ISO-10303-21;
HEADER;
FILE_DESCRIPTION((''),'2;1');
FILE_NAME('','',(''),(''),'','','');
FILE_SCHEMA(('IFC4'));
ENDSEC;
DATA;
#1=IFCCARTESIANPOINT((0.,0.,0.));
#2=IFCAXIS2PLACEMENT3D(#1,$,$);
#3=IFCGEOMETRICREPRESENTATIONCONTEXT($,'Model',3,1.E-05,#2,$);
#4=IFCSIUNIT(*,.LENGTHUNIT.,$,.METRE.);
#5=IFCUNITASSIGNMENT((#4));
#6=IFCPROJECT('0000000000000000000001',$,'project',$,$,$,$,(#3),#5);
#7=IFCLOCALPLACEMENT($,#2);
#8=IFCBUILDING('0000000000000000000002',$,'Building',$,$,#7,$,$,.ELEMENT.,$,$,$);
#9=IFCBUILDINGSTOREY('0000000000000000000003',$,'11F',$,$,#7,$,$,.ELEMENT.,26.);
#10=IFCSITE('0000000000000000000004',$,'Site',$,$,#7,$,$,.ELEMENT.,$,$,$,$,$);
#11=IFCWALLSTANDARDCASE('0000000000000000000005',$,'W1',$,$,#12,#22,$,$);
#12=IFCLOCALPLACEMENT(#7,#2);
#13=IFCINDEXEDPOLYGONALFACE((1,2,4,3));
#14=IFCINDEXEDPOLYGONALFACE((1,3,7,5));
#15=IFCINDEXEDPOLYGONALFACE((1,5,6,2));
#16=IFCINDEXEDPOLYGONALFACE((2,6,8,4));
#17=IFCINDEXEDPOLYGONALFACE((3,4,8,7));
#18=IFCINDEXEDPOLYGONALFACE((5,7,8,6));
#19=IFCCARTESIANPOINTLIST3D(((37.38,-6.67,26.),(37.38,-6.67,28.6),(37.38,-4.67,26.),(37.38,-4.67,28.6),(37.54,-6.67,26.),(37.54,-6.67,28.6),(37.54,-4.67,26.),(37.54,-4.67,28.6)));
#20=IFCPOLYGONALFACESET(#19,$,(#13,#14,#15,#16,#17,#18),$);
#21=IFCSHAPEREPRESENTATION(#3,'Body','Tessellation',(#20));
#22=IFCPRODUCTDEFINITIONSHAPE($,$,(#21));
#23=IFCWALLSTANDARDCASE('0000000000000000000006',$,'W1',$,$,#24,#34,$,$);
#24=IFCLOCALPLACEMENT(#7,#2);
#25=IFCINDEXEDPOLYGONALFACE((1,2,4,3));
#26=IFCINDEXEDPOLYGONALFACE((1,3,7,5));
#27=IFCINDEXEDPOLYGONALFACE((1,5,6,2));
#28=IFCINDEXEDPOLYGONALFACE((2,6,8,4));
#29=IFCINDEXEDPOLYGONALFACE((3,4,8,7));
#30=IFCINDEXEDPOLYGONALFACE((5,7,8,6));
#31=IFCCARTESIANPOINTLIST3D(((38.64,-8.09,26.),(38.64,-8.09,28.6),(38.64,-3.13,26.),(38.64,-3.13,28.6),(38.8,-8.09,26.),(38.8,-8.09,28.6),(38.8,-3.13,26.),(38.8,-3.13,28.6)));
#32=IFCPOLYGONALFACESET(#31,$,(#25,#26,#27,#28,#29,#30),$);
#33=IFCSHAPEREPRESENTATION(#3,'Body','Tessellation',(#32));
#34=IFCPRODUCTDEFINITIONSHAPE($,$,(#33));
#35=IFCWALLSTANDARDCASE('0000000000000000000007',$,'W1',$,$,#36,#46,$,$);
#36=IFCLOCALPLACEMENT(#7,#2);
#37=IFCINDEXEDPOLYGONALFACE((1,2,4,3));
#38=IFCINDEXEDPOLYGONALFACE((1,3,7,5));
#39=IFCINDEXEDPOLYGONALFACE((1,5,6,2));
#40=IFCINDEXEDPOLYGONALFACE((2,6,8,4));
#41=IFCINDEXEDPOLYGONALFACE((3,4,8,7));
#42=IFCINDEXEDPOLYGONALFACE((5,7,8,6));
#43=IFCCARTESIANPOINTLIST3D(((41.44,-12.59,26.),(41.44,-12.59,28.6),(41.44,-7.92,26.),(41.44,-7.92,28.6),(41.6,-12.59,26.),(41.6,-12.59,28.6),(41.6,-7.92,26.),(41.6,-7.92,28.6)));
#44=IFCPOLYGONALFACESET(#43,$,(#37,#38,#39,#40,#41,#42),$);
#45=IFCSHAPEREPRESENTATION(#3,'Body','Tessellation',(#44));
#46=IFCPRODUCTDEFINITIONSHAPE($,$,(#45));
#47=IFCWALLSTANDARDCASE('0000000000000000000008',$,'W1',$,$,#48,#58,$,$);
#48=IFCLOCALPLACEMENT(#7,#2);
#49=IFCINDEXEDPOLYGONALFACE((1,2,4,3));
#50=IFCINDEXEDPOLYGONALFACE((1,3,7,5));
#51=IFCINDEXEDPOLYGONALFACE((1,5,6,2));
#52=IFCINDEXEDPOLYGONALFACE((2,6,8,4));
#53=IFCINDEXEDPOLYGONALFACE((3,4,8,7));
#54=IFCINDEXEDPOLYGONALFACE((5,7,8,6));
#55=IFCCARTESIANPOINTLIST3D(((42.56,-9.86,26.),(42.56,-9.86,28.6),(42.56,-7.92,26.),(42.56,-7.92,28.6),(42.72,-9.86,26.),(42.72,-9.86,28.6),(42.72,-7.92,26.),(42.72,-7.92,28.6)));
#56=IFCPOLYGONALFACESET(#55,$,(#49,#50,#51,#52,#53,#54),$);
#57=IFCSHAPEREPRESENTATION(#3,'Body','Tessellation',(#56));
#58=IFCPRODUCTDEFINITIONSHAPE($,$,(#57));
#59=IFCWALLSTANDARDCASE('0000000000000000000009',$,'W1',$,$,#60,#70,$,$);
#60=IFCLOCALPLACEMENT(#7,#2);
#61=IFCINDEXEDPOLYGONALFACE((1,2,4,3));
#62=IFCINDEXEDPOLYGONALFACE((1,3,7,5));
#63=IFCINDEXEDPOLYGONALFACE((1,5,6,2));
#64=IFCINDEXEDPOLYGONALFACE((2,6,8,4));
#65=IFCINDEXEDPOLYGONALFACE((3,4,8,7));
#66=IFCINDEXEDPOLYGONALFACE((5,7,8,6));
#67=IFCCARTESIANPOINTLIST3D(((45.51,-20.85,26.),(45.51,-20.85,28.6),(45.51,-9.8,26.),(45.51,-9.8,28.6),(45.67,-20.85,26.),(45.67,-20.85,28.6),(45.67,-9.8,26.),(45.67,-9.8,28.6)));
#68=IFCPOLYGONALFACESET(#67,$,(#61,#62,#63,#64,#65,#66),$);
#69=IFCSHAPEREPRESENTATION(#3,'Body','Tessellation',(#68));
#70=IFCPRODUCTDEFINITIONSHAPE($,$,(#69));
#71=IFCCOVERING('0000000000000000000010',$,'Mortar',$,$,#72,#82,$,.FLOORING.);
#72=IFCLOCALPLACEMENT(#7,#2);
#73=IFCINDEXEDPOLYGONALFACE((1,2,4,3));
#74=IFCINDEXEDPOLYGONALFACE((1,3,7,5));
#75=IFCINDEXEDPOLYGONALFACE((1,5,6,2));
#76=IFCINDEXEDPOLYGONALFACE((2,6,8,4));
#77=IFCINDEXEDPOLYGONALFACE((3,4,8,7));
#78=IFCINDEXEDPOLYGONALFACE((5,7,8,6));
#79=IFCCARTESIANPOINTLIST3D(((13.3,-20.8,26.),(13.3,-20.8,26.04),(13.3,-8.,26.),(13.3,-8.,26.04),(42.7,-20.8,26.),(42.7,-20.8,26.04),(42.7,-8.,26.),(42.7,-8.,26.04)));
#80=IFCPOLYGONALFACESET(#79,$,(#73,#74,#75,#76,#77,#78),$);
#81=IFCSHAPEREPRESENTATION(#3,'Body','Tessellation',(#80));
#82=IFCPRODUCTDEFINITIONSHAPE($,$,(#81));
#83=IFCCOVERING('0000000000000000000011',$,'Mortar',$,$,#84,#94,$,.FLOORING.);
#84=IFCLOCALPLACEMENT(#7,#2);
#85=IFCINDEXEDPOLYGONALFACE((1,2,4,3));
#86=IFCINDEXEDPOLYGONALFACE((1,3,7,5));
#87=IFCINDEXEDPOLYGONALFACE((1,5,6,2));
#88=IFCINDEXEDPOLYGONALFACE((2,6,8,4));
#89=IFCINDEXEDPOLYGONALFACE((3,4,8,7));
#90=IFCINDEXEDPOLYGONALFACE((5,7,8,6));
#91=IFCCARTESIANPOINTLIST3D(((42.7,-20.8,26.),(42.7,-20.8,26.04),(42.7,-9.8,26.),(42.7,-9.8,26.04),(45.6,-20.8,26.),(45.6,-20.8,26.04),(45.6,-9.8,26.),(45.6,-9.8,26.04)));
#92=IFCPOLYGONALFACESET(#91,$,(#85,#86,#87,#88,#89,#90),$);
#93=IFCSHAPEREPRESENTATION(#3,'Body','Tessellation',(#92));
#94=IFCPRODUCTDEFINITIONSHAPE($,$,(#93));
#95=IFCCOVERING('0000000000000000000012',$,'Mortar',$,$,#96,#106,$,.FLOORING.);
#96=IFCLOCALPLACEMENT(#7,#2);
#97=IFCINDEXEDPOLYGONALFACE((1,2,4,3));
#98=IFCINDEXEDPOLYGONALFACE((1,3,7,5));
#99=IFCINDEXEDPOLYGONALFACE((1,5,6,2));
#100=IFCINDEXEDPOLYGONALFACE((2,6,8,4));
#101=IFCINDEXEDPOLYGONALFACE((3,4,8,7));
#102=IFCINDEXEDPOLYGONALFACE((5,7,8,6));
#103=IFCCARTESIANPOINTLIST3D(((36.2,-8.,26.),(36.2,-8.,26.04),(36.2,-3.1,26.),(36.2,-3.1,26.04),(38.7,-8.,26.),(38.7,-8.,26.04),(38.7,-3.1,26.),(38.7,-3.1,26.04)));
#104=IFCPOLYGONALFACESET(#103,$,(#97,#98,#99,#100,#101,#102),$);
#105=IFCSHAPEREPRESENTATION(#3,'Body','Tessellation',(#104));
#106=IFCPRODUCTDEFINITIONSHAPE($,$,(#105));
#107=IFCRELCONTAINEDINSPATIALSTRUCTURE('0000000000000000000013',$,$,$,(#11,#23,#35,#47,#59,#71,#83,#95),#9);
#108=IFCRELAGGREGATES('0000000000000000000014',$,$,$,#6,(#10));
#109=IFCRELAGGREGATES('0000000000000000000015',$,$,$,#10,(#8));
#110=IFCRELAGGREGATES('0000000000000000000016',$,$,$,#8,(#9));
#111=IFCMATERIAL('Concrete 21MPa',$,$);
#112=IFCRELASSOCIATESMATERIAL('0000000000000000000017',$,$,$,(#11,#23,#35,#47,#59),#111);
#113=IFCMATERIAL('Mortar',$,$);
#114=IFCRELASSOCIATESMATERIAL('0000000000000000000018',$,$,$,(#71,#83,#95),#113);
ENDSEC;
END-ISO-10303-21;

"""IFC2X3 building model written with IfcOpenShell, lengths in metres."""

from ifc_helpers import new_model, si_unit, frame, origin, origin_2d, place, context, project, spatial, rectangle, extrude, material, element, save


model = new_model("IFC2X3")

# Units and contexts
model_context = context("Model", 3, precision=1e-05, world=origin())
ifc_project = project(units=[si_unit("LENGTHUNIT", "METRE")], contexts=[model_context])

# Site, building, storey
placement = place(None, origin())
site = spatial("IfcSite", under=ifc_project, at=placement, Name="Site", CompositionType="ELEMENT")
building = spatial("IfcBuilding", under=site, at=placement, Name="Building", CompositionType="ELEMENT")
storey = spatial("IfcBuildingStorey", under=building, at=placement, Name="11F", CompositionType="ELEMENT", Elevation=26.0)

# Shared definitions
ifc_material_1 = material(Name="Concrete 21MPa")

# Walls
wall_1_placement = place(None, frame((37.46, -5.67, 26.0)))
element("IfcWallStandardCase", 1, at=wall_1_placement, inside=storey, material=ifc_material_1, Name="W1", context=model_context, shape_type="SweptSolid", body=[
    extrude(rectangle(XDim=0.16, YDim=2.0, at=origin_2d()), origin(), (0.0, 0.0, 1.0), 2.6),
])
wall_2_placement = place(None, frame((38.72, -5.61, 26.0)))
element("IfcWallStandardCase", 2, at=wall_2_placement, inside=storey, material=ifc_material_1, Name="W1", context=model_context, shape_type="SweptSolid", body=[
    extrude(rectangle(XDim=0.16, YDim=4.96, at=origin_2d()), origin(), (0.0, 0.0, 1.0), 2.6),
])
wall_3_placement = place(None, frame((41.52, -10.255, 26.0)))
element("IfcWallStandardCase", 3, at=wall_3_placement, inside=storey, material=ifc_material_1, Name="W1", context=model_context, shape_type="SweptSolid", body=[
    extrude(rectangle(XDim=0.16, YDim=4.67, at=origin_2d()), origin(), (0.0, 0.0, 1.0), 2.6),
])
wall_4_placement = place(None, frame((42.64, -8.89, 26.0)))
element("IfcWallStandardCase", 4, at=wall_4_placement, inside=storey, material=ifc_material_1, Name="W1", context=model_context, shape_type="SweptSolid", body=[
    extrude(rectangle(XDim=0.16, YDim=1.94, at=origin_2d()), origin(), (0.0, 0.0, 1.0), 2.6),
])
wall_5_placement = place(None, frame((45.59, -15.325, 26.0)))
element("IfcWallStandardCase", 5, at=wall_5_placement, inside=storey, material=ifc_material_1, Name="W1", context=model_context, shape_type="SweptSolid", body=[
    extrude(rectangle(XDim=0.16, YDim=11.05, at=origin_2d()), origin(), (0.0, 0.0, 1.0), 2.6),
])

# Coverings
ifc_material_2 = material(Name="Mortar")
covering_1_placement = place(None, frame((28.0, -14.4, 26.0)))
element("IfcCovering", 6, at=covering_1_placement, inside=storey, material=ifc_material_2, Name="Mortar", PredefinedType="FLOORING", context=model_context, shape_type="SweptSolid", body=[
    extrude(rectangle(XDim=29.4, YDim=12.8, at=origin_2d()), origin(), (0.0, 0.0, 1.0), 0.04),
])
covering_2_placement = place(None, frame((44.15, -15.3, 26.0)))
element("IfcCovering", 7, at=covering_2_placement, inside=storey, material=ifc_material_2, Name="Mortar", PredefinedType="FLOORING", context=model_context, shape_type="SweptSolid", body=[
    extrude(rectangle(XDim=2.9, YDim=11.0, at=origin_2d()), origin(), (0.0, 0.0, 1.0), 0.04),
])
covering_3_placement = place(None, frame((37.45, -5.55, 26.0)))
element("IfcCovering", 8, at=covering_3_placement, inside=storey, material=ifc_material_2, Name="Mortar", PredefinedType="FLOORING", context=model_context, shape_type="SweptSolid", body=[
    extrude(rectangle(XDim=2.5, YDim=4.9, at=origin_2d()), origin(), (0.0, 0.0, 1.0), 0.04),
])

save(model, "model.ifc")
